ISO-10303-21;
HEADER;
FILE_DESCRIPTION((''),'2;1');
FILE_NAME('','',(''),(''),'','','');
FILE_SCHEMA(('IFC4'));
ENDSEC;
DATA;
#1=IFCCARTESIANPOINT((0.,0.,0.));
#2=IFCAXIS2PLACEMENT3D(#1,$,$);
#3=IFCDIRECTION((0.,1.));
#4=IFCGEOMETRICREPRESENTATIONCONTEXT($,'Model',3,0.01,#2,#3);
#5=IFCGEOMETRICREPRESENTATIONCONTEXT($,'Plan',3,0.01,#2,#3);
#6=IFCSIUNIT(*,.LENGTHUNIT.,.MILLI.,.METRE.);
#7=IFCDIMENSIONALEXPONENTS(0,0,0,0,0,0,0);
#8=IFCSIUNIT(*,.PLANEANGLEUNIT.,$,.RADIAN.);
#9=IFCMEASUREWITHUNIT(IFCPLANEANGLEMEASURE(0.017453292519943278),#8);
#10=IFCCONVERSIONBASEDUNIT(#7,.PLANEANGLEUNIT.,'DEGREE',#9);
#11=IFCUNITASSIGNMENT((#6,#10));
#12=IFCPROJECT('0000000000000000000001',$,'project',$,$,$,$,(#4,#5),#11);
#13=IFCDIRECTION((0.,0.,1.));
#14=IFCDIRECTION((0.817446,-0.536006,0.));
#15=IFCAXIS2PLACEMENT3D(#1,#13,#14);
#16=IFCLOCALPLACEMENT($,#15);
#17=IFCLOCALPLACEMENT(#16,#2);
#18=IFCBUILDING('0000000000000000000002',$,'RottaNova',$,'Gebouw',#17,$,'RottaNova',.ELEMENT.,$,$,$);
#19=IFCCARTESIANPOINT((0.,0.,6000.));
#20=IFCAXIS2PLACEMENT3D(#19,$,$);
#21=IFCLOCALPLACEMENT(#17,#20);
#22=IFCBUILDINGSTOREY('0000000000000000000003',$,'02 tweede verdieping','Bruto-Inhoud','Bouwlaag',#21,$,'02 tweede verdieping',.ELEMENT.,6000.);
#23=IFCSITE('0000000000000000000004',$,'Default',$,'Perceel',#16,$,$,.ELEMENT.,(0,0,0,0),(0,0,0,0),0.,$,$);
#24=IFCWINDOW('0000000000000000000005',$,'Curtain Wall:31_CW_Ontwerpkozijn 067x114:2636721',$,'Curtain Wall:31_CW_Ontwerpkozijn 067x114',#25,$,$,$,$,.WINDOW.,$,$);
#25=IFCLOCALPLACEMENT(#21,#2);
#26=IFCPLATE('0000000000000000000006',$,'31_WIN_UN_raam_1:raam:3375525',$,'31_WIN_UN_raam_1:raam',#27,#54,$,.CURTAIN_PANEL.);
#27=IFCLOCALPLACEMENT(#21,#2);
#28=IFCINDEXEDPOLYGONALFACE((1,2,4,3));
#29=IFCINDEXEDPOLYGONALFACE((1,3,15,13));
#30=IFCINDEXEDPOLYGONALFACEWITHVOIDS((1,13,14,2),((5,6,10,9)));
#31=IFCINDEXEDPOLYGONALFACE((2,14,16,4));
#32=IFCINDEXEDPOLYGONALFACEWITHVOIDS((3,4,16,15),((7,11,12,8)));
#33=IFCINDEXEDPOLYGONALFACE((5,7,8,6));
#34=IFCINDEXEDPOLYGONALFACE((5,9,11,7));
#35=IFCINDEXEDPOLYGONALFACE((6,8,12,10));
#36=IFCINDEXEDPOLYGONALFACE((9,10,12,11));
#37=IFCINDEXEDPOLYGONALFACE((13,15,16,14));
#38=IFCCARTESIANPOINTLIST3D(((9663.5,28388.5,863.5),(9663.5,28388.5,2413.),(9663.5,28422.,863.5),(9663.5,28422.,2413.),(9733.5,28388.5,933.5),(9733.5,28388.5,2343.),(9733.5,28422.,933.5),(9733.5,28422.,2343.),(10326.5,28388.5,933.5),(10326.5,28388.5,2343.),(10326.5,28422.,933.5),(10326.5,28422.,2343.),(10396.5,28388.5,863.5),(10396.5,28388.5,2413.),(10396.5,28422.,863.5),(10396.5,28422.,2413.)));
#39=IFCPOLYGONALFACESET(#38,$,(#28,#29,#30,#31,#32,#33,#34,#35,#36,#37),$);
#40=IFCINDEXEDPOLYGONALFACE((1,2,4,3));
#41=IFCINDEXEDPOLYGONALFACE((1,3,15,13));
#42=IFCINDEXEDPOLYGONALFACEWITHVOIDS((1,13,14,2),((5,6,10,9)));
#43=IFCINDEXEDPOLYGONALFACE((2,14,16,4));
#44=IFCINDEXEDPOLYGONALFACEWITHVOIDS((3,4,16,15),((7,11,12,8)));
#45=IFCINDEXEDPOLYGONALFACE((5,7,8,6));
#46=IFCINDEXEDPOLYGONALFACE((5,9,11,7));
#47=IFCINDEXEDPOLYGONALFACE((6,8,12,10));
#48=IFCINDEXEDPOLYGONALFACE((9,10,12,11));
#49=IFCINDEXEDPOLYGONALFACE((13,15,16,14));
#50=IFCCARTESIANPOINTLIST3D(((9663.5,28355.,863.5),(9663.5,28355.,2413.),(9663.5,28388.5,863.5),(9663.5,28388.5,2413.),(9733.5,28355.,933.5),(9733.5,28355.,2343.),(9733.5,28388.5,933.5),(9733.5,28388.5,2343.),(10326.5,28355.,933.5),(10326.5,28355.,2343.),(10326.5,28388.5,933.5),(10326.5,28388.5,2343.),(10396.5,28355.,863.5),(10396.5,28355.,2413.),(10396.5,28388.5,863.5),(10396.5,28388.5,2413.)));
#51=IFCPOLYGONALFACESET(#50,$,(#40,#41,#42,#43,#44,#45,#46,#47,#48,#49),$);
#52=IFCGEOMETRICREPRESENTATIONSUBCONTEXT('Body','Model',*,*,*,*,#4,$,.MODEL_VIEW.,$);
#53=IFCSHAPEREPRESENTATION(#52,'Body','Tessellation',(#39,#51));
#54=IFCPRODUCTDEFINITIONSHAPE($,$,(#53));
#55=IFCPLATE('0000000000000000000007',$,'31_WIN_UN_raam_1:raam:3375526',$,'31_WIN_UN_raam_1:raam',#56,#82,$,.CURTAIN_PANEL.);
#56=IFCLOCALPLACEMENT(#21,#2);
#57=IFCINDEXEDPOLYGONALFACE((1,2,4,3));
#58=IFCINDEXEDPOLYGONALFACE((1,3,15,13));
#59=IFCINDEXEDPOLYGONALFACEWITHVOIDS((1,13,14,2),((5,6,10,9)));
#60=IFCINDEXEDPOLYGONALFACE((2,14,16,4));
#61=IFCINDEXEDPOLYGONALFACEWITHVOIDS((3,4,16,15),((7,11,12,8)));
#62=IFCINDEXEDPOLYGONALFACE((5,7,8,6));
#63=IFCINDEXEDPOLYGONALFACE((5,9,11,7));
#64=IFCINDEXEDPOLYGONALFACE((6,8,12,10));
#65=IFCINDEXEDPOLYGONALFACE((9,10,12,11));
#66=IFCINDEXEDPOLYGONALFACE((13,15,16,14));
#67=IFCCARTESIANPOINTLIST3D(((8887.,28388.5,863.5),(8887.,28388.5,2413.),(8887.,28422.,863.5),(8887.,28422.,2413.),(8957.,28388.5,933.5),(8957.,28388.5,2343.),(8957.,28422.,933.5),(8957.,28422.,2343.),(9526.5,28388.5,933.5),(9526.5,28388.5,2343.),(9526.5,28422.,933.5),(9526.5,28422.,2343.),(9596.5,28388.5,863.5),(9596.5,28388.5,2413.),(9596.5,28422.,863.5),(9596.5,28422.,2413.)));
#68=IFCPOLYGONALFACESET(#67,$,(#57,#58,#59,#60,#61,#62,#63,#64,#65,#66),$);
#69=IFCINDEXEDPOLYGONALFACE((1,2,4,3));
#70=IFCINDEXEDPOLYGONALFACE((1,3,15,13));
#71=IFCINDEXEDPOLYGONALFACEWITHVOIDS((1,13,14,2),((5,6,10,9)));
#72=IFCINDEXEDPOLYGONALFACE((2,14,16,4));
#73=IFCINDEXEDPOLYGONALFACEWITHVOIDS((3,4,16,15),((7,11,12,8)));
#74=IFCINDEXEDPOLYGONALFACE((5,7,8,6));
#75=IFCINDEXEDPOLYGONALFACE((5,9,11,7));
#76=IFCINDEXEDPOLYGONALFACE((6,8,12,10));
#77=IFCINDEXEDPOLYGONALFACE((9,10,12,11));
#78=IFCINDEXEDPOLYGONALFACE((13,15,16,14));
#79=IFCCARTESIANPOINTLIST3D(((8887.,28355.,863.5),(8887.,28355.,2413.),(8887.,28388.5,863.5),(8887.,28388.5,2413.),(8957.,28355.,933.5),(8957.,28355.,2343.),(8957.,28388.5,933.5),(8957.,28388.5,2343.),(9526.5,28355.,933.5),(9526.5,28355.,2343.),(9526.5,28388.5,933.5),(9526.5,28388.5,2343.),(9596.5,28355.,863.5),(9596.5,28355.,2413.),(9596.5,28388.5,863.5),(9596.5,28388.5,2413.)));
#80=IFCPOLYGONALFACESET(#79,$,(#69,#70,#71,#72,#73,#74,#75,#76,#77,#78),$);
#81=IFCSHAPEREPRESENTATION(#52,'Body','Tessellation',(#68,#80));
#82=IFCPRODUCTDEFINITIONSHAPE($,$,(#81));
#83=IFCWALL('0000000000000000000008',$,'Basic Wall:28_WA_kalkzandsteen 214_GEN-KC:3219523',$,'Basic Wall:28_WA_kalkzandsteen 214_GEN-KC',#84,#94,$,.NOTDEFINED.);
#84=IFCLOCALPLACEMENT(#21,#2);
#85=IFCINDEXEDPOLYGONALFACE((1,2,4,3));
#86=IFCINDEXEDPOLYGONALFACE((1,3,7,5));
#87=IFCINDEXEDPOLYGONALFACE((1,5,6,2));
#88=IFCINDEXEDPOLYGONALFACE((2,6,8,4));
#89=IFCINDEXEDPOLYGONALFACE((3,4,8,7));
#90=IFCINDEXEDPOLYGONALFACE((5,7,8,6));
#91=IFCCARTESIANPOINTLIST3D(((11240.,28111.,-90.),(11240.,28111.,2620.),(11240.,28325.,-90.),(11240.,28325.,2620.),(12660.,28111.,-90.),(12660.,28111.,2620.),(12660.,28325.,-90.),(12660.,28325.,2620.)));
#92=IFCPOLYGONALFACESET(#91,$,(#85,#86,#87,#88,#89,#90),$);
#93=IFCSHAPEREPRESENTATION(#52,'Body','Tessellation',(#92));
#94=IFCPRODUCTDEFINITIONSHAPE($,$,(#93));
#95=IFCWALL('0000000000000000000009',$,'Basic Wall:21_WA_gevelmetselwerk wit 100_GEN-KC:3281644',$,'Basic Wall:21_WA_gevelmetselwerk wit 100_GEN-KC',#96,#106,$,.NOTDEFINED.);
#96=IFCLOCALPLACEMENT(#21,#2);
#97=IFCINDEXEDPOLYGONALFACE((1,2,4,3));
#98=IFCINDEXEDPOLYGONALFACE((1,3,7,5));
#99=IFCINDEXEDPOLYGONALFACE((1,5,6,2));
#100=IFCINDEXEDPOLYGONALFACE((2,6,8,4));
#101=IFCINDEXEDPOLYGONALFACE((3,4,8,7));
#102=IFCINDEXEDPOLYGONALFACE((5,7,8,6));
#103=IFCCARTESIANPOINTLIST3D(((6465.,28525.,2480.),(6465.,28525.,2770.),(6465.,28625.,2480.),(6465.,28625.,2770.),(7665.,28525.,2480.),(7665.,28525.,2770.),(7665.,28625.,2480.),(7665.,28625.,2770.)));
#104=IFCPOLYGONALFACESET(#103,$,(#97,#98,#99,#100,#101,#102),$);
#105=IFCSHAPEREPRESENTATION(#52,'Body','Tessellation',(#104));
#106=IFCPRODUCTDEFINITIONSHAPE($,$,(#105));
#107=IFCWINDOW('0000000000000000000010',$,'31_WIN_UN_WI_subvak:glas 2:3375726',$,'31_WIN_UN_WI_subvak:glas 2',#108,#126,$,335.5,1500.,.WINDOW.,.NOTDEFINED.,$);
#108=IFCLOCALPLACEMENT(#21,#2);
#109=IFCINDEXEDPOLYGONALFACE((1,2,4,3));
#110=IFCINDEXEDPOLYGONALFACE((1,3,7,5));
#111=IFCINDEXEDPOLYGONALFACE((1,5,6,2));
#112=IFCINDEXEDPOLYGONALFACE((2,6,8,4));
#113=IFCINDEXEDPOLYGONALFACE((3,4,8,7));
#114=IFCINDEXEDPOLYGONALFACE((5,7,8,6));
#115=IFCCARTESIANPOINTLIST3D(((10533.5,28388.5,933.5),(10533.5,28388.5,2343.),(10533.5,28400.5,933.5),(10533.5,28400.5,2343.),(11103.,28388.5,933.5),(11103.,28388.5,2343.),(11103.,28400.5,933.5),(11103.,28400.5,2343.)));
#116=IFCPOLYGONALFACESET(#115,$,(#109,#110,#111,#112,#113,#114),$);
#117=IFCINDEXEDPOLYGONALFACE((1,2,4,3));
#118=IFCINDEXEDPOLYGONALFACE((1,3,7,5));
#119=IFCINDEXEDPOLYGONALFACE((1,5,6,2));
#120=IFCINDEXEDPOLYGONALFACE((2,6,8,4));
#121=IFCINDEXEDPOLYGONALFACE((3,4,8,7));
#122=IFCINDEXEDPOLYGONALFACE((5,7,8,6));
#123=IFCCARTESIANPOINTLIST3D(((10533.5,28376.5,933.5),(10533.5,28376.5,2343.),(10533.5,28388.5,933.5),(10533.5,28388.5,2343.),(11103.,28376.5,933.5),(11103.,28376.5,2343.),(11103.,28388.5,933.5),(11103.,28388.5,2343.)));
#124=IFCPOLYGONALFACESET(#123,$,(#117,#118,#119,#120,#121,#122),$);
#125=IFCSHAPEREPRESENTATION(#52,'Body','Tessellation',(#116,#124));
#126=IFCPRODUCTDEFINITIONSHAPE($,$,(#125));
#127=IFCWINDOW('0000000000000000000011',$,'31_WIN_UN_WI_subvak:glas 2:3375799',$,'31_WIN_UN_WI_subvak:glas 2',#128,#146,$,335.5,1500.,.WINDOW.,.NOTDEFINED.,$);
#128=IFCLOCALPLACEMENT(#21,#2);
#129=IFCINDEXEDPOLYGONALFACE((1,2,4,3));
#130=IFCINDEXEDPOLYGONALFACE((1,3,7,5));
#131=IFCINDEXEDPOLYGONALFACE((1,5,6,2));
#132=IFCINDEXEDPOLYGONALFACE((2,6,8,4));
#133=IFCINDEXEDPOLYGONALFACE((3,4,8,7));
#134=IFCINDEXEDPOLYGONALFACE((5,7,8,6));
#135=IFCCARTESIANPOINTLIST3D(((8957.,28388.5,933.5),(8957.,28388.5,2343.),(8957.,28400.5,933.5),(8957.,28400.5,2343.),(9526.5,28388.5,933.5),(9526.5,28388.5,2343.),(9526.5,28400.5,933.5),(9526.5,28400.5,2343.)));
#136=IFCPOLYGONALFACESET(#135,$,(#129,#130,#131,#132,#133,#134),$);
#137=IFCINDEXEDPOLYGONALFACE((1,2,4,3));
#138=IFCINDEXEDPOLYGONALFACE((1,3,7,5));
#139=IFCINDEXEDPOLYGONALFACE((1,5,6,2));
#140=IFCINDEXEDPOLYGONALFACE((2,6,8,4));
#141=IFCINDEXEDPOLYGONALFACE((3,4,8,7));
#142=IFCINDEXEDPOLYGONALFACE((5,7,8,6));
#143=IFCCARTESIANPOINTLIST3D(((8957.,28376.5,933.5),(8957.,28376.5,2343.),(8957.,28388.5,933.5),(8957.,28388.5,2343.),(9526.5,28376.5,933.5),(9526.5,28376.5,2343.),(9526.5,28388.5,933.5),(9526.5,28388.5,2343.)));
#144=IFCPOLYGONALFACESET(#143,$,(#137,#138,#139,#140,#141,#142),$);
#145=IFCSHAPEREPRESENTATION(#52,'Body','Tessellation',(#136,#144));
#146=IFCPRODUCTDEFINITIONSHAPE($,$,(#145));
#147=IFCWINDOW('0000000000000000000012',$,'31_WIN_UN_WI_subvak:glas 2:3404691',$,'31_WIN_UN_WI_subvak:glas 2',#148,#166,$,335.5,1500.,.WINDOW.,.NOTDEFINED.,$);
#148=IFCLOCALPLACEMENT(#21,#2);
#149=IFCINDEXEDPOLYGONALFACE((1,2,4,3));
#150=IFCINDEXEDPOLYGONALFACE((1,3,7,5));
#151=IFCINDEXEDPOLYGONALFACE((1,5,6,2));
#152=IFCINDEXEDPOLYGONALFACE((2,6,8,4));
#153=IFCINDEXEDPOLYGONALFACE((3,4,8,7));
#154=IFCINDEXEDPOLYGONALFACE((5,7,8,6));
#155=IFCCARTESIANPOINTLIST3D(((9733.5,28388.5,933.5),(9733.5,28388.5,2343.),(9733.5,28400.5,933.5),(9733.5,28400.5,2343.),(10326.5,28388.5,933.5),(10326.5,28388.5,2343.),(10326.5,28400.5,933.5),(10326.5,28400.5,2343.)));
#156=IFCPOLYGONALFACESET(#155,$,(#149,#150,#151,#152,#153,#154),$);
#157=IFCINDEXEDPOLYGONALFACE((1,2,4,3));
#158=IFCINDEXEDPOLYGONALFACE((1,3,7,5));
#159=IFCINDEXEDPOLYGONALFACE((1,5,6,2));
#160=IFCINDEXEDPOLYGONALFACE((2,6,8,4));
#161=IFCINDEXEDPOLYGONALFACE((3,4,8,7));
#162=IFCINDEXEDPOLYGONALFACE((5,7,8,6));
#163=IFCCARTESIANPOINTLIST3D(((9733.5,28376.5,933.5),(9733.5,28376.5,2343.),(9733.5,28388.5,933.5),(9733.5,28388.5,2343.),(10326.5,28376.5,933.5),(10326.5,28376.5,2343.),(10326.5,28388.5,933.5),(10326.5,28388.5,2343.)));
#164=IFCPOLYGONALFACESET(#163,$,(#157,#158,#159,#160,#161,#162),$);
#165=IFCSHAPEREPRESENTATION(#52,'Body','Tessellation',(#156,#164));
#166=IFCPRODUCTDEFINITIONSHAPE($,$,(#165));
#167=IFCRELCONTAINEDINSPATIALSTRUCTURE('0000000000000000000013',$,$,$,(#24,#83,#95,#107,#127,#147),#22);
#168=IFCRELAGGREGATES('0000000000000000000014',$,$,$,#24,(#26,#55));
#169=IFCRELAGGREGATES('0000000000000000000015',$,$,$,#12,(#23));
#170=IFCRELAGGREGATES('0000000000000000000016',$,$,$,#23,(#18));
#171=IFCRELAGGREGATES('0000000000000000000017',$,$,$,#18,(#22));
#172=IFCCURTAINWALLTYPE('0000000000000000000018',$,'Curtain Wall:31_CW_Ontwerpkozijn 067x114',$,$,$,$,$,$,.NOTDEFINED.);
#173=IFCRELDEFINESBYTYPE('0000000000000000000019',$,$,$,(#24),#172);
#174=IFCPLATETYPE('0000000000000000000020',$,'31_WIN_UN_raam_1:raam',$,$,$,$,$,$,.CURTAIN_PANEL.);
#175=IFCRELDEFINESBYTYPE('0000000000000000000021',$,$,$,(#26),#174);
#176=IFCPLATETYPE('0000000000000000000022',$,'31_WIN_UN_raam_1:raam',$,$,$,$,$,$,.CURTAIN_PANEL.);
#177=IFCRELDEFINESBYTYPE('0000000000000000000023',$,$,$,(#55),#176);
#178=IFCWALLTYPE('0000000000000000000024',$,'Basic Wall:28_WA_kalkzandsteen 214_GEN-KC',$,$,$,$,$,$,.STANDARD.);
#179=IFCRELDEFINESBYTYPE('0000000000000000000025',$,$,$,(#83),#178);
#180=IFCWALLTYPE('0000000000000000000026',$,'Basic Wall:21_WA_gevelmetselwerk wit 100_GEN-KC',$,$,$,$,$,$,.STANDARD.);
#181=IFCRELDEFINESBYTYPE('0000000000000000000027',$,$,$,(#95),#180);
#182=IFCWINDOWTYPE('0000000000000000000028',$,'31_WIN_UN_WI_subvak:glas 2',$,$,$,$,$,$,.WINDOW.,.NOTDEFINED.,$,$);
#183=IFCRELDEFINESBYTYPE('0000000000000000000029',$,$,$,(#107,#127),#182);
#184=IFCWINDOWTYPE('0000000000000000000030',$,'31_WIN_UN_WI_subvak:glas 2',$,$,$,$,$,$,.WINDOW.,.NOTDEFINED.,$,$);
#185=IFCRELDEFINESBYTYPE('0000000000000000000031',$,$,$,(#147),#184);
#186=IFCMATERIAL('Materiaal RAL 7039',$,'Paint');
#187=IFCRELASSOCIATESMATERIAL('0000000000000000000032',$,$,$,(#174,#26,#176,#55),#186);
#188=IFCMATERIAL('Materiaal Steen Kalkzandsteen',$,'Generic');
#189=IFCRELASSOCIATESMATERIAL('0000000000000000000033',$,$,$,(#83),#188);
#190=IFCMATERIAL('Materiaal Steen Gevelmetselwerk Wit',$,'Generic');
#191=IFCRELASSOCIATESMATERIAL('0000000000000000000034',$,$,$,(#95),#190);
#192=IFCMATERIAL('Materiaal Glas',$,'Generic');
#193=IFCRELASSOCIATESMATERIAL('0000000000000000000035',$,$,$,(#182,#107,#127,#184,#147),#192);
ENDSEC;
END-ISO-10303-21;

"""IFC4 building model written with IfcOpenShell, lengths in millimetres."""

from ifc_helpers import new_model, entity, si_unit, converted_unit, direction, frame, origin, place, context, subcontext, project, spatial, indexed_curve, outline, extrude, source, transform, mapped, material, type_object, type_shapes, element, aggregate, save


model = new_model("IFC4")

# Units and contexts
model_context = context("Model", 3, precision=0.01, world=origin(), true_north=direction((0.0, 1.0)))
plan_context = context("Plan", 3, precision=0.01, world=origin(), true_north=direction((0.0, 1.0)))
body_context = subcontext(model_context, "Body", "Model", "MODEL_VIEW")
ifc_project = project(units=[si_unit("LENGTHUNIT", "METRE", prefix="MILLI"), converted_unit("PLANEANGLEUNIT", "DEGREE", entity("IfcPlaneAngleMeasure", 0.017453292519943278), si_unit("PLANEANGLEUNIT", "RADIAN"), dimensions=[0, 0, 0, 0, 0, 0, 0])], contexts=[model_context, plan_context])

# Site, building, storey
site_placement = place(None, frame((0.0, 0.0, 0.0), z_axis=(0.0, 0.0, 1.0), x_axis=(0.817446, -0.536006, 0.0)))
site = spatial("IfcSite", under=ifc_project, at=site_placement, Name="Default", ObjectType="Perceel", CompositionType="ELEMENT", RefLatitude=(0, 0, 0, 0), RefLongitude=(0, 0, 0, 0), RefElevation=0.0)
building_placement = place(site_placement, origin())
building = spatial("IfcBuilding", under=site, at=building_placement, Name="RottaNova", ObjectType="Gebouw", LongName="RottaNova", CompositionType="ELEMENT")
storey_placement = place(building_placement, frame((0.0, 0.0, 6000.0)))
storey = spatial("IfcBuildingStorey", under=building, at=storey_placement, Name="02 tweede verdieping", Description="Bruto-Inhoud", ObjectType="Bouwlaag", LongName="02 tweede verdieping", CompositionType="ELEMENT", Elevation=6000.0)

# Window
curtain_wall_type = type_object("IfcCurtainWallType", Name="Curtain Wall:31_CW_Ontwerpkozijn 067x114", PredefinedType="NOTDEFINED")
window_1_placement = place(storey_placement, frame((0.0, 0.0, -6000.0)))
window_1 = element("IfcWindow", 1, at=window_1_placement, inside=storey, type_object=curtain_wall_type, Name="Curtain Wall:31_CW_Ontwerpkozijn 067x114:2636721", ObjectType="Curtain Wall:31_CW_Ontwerpkozijn 067x114", PredefinedType="WINDOW")

# Plates
ifc_material_1 = material(Name="Materiaal Glas", Category="Generic")
ifc_material_2 = material(Name="Materiaal RAL 7039", Category="Paint")
plate_type_1 = type_object("IfcPlateType", Name="31_WIN_UN_raam_1:raam", PredefinedType="CURTAIN_PANEL", material=ifc_material_2)
shared_shape_1 = source(origin(), body_context, "Body", "SweptSolid", [
    extrude(outline(indexed_curve([(-366.5, -774.7), (366.5, -774.7), (366.5, 774.7), (-366.5, 774.7), (-366.5, -774.7)], self_intersect=False), holes=[indexed_curve([(-296.5, 704.7), (296.5, 704.7), (296.5, -704.8), (-296.5, -704.8), (-296.5, 704.7)], self_intersect=False)]), frame((0.0, -92.0, 774.8), z_axis=(0.0, 1.0, 0.0), x_axis=(1.0, 0.0, 0.0)), (0.0, 0.0, 1.0), 33.5),
    extrude(outline(indexed_curve([(-366.5, -774.7), (366.5, -774.7), (366.5, 774.7), (-366.5, 774.7), (-366.5, -774.7)], self_intersect=False), holes=[indexed_curve([(-296.5, 704.7), (296.5, 704.7), (296.5, -704.8), (-296.5, -704.8), (-296.5, 704.7)], self_intersect=False)]), frame((0.0, -58.5, 774.8), z_axis=(0.0, 1.0, 0.0), x_axis=(1.0, 0.0, 0.0)), (0.0, 0.0, 1.0), 33.5),
])
type_shapes(plate_type_1, [shared_shape_1])
plate_1_placement = place(window_1_placement, frame((10030.0, 28330.0, 6863.5), z_axis=(0.0, 0.0, 1.0), x_axis=(-1.0, 0.0, 0.0)))
plate_1 = element("IfcPlate", 2, at=plate_1_placement, type_object=plate_type_1, material=ifc_material_2, Name="31_WIN_UN_raam_1:raam:3375525", ObjectType="31_WIN_UN_raam_1:raam", PredefinedType="CURTAIN_PANEL", context=body_context, shape_type="MappedRepresentation", body=[
    mapped(shared_shape_1, transform((0.0, 0.0, 0.0), scale=1.0)),
])
plate_type_2 = type_object("IfcPlateType", Name="31_WIN_UN_raam_1:raam", PredefinedType="CURTAIN_PANEL", material=ifc_material_2)
shared_shape_2 = source(origin(), body_context, "Body", "SweptSolid", [
    extrude(outline(indexed_curve([(-354.7, -774.7), (354.7, -774.7), (354.7, 774.7), (-354.7, 774.7), (-354.7, -774.7)], self_intersect=False), holes=[indexed_curve([(-284.7, 704.7), (284.7, 704.7), (284.7, -704.8), (-284.7, -704.8), (-284.7, 704.7)], self_intersect=False)]), frame((0.0, -92.0, 774.8), z_axis=(0.0, 1.0, 0.0), x_axis=(1.0, 0.0, 0.0)), (0.0, 0.0, 1.0), 33.5),
    extrude(outline(indexed_curve([(-354.7, -774.7), (354.7, -774.7), (354.7, 774.7), (-354.7, 774.7), (-354.7, -774.7)], self_intersect=False), holes=[indexed_curve([(-284.7, 704.7), (284.7, 704.7), (284.7, -704.8), (-284.7, -704.8), (-284.7, 704.7)], self_intersect=False)]), frame((0.0, -58.5, 774.8), z_axis=(0.0, 1.0, 0.0), x_axis=(1.0, 0.0, 0.0)), (0.0, 0.0, 1.0), 33.5),
])
type_shapes(plate_type_2, [shared_shape_2])
plate_2_placement = place(window_1_placement, frame((9241.7, 28330.0, 6863.5), z_axis=(0.0, 0.0, 1.0), x_axis=(-1.0, 0.0, 0.0)))
plate_2 = element("IfcPlate", 3, at=plate_2_placement, type_object=plate_type_2, material=ifc_material_2, Name="31_WIN_UN_raam_1:raam:3375526", ObjectType="31_WIN_UN_raam_1:raam", PredefinedType="CURTAIN_PANEL", context=body_context, shape_type="MappedRepresentation", body=[
    mapped(shared_shape_2, transform((0.0, 0.0, 0.0), scale=1.0)),
])
aggregate(window_1, [plate_1, plate_2])

# Walls
ifc_material_3 = material(Name="Materiaal Steen Kalkzandsteen", Category="Generic")
wall_type_1 = type_object("IfcWallType", Name="Basic Wall:28_WA_kalkzandsteen 214_GEN-KC", PredefinedType="STANDARD")
wall_1_placement = place(storey_placement, frame((11240.0, 28218.0, -90.0)))
element("IfcWall", 4, at=wall_1_placement, inside=storey, type_object=wall_type_1, material=ifc_material_3, Name="Basic Wall:28_WA_kalkzandsteen 214_GEN-KC:3219523", ObjectType="Basic Wall:28_WA_kalkzandsteen 214_GEN-KC", PredefinedType="NOTDEFINED", context=body_context, shape_type="SweptSolid", body=[
    extrude(outline(indexed_curve([(1420.0, 107.0), (0.0, 107.0), (0.0, -107.0), (1420.0, -107.0), (1420.0, 107.0)], self_intersect=False)), origin(), (0.0, 0.0, 1.0), 2710.0),
])
ifc_material_4 = material(Name="Materiaal Steen Gevelmetselwerk Wit", Category="Generic")
wall_type_2 = type_object("IfcWallType", Name="Basic Wall:21_WA_gevelmetselwerk wit 100_GEN-KC", PredefinedType="STANDARD")
wall_2_placement = place(storey_placement, frame((7665.0, 28575.0, 2480.0), z_axis=(0.0, 0.0, 1.0), x_axis=(-1.0, 0.0, 0.0)))
element("IfcWall", 5, at=wall_2_placement, inside=storey, type_object=wall_type_2, material=ifc_material_4, Name="Basic Wall:21_WA_gevelmetselwerk wit 100_GEN-KC:3281644", ObjectType="Basic Wall:21_WA_gevelmetselwerk wit 100_GEN-KC", PredefinedType="NOTDEFINED", context=body_context, shape_type="SweptSolid", body=[
    extrude(outline(indexed_curve([(1200.0, 50.0), (0.0, 50.0), (0.0, -50.0), (1200.0, -50.0), (1200.0, 50.0)], self_intersect=False)), origin(), (0.0, 0.0, 1.0), 290.0),
])

# Windows
window_type_1 = type_object("IfcWindowType", Name="31_WIN_UN_WI_subvak:glas 2", PartitioningType="NOTDEFINED", PredefinedType="WINDOW", material=ifc_material_1)
shared_shape_3 = source(origin(), body_context, "Body", "SweptSolid", [
    extrude(outline(indexed_curve([(-284.7, -6.0), (284.7, -6.0), (284.7, 6.0), (-284.7, 6.0), (-284.7, -6.0)], self_intersect=False)), frame((0.0, -6.0, 0.0)), (0.0, 0.0, 1.0), 1409.5),
    extrude(outline(indexed_curve([(-284.8, -6.0), (284.8, -6.0), (284.8, 6.0), (-284.8, 6.0), (-284.8, -6.0)], self_intersect=False)), frame((0.0, 6.0, 0.0)), (0.0, 0.0, 1.0), 1409.5),
])
type_shapes(window_type_1, [shared_shape_3])
for number, where, z_axis, x_axis, name in (
    (6, (10818.2, 28388.5, 933.5), (0.0, 0.0, 1.0), (-1.0, 0.0, 0.0), "31_WIN_UN_WI_subvak:glas 2:3375726"),
    (7, (9241.7, 28388.5, 933.5), (0.0, 0.0, 1.0), (-1.0, 0.0, 0.0), "31_WIN_UN_WI_subvak:glas 2:3375799"),
):
    element("IfcWindow", number, at=place(storey_placement, frame(where, z_axis=z_axis, x_axis=x_axis)), inside=storey, type_object=window_type_1, material=ifc_material_1, Name=name, ObjectType="31_WIN_UN_WI_subvak:glas 2", OverallHeight=335.5, OverallWidth=1500.0, PartitioningType="NOTDEFINED", PredefinedType="WINDOW", context=body_context, shape_type="MappedRepresentation", body=[
        mapped(shared_shape_3, transform((0.0, 0.0, 0.0), scale=1.0)),
    ])
window_type_2 = type_object("IfcWindowType", Name="31_WIN_UN_WI_subvak:glas 2", PartitioningType="NOTDEFINED", PredefinedType="WINDOW", material=ifc_material_1)
shared_shape_4 = source(origin(), body_context, "Body", "SweptSolid", [
    extrude(outline(indexed_curve([(-296.5, -6.0), (296.5, -6.0), (296.5, 6.0), (-296.5, 6.0), (-296.5, -6.0)], self_intersect=False)), frame((0.0, -6.0, 0.0)), (0.0, 0.0, 1.0), 1409.5),
    extrude(outline(indexed_curve([(-296.5, -6.0), (296.5, -6.0), (296.5, 6.0), (-296.5, 6.0), (-296.5, -6.0)], self_intersect=False)), frame((0.0, 6.0, 0.0)), (0.0, 0.0, 1.0), 1409.5),
])
type_shapes(window_type_2, [shared_shape_4])
window_2_placement = place(storey_placement, frame((10030.0, 28388.5, 933.5), z_axis=(0.0, 0.0, 1.0), x_axis=(-1.0, 0.0, 0.0)))
element("IfcWindow", 8, at=window_2_placement, inside=storey, type_object=window_type_2, material=ifc_material_1, Name="31_WIN_UN_WI_subvak:glas 2:3404691", ObjectType="31_WIN_UN_WI_subvak:glas 2", OverallHeight=335.5, OverallWidth=1500.0, PartitioningType="NOTDEFINED", PredefinedType="WINDOW", context=body_context, shape_type="MappedRepresentation", body=[
    mapped(shared_shape_4, transform((0.0, 0.0, 0.0), scale=1.0)),
])

save(model, "model.ifc")
